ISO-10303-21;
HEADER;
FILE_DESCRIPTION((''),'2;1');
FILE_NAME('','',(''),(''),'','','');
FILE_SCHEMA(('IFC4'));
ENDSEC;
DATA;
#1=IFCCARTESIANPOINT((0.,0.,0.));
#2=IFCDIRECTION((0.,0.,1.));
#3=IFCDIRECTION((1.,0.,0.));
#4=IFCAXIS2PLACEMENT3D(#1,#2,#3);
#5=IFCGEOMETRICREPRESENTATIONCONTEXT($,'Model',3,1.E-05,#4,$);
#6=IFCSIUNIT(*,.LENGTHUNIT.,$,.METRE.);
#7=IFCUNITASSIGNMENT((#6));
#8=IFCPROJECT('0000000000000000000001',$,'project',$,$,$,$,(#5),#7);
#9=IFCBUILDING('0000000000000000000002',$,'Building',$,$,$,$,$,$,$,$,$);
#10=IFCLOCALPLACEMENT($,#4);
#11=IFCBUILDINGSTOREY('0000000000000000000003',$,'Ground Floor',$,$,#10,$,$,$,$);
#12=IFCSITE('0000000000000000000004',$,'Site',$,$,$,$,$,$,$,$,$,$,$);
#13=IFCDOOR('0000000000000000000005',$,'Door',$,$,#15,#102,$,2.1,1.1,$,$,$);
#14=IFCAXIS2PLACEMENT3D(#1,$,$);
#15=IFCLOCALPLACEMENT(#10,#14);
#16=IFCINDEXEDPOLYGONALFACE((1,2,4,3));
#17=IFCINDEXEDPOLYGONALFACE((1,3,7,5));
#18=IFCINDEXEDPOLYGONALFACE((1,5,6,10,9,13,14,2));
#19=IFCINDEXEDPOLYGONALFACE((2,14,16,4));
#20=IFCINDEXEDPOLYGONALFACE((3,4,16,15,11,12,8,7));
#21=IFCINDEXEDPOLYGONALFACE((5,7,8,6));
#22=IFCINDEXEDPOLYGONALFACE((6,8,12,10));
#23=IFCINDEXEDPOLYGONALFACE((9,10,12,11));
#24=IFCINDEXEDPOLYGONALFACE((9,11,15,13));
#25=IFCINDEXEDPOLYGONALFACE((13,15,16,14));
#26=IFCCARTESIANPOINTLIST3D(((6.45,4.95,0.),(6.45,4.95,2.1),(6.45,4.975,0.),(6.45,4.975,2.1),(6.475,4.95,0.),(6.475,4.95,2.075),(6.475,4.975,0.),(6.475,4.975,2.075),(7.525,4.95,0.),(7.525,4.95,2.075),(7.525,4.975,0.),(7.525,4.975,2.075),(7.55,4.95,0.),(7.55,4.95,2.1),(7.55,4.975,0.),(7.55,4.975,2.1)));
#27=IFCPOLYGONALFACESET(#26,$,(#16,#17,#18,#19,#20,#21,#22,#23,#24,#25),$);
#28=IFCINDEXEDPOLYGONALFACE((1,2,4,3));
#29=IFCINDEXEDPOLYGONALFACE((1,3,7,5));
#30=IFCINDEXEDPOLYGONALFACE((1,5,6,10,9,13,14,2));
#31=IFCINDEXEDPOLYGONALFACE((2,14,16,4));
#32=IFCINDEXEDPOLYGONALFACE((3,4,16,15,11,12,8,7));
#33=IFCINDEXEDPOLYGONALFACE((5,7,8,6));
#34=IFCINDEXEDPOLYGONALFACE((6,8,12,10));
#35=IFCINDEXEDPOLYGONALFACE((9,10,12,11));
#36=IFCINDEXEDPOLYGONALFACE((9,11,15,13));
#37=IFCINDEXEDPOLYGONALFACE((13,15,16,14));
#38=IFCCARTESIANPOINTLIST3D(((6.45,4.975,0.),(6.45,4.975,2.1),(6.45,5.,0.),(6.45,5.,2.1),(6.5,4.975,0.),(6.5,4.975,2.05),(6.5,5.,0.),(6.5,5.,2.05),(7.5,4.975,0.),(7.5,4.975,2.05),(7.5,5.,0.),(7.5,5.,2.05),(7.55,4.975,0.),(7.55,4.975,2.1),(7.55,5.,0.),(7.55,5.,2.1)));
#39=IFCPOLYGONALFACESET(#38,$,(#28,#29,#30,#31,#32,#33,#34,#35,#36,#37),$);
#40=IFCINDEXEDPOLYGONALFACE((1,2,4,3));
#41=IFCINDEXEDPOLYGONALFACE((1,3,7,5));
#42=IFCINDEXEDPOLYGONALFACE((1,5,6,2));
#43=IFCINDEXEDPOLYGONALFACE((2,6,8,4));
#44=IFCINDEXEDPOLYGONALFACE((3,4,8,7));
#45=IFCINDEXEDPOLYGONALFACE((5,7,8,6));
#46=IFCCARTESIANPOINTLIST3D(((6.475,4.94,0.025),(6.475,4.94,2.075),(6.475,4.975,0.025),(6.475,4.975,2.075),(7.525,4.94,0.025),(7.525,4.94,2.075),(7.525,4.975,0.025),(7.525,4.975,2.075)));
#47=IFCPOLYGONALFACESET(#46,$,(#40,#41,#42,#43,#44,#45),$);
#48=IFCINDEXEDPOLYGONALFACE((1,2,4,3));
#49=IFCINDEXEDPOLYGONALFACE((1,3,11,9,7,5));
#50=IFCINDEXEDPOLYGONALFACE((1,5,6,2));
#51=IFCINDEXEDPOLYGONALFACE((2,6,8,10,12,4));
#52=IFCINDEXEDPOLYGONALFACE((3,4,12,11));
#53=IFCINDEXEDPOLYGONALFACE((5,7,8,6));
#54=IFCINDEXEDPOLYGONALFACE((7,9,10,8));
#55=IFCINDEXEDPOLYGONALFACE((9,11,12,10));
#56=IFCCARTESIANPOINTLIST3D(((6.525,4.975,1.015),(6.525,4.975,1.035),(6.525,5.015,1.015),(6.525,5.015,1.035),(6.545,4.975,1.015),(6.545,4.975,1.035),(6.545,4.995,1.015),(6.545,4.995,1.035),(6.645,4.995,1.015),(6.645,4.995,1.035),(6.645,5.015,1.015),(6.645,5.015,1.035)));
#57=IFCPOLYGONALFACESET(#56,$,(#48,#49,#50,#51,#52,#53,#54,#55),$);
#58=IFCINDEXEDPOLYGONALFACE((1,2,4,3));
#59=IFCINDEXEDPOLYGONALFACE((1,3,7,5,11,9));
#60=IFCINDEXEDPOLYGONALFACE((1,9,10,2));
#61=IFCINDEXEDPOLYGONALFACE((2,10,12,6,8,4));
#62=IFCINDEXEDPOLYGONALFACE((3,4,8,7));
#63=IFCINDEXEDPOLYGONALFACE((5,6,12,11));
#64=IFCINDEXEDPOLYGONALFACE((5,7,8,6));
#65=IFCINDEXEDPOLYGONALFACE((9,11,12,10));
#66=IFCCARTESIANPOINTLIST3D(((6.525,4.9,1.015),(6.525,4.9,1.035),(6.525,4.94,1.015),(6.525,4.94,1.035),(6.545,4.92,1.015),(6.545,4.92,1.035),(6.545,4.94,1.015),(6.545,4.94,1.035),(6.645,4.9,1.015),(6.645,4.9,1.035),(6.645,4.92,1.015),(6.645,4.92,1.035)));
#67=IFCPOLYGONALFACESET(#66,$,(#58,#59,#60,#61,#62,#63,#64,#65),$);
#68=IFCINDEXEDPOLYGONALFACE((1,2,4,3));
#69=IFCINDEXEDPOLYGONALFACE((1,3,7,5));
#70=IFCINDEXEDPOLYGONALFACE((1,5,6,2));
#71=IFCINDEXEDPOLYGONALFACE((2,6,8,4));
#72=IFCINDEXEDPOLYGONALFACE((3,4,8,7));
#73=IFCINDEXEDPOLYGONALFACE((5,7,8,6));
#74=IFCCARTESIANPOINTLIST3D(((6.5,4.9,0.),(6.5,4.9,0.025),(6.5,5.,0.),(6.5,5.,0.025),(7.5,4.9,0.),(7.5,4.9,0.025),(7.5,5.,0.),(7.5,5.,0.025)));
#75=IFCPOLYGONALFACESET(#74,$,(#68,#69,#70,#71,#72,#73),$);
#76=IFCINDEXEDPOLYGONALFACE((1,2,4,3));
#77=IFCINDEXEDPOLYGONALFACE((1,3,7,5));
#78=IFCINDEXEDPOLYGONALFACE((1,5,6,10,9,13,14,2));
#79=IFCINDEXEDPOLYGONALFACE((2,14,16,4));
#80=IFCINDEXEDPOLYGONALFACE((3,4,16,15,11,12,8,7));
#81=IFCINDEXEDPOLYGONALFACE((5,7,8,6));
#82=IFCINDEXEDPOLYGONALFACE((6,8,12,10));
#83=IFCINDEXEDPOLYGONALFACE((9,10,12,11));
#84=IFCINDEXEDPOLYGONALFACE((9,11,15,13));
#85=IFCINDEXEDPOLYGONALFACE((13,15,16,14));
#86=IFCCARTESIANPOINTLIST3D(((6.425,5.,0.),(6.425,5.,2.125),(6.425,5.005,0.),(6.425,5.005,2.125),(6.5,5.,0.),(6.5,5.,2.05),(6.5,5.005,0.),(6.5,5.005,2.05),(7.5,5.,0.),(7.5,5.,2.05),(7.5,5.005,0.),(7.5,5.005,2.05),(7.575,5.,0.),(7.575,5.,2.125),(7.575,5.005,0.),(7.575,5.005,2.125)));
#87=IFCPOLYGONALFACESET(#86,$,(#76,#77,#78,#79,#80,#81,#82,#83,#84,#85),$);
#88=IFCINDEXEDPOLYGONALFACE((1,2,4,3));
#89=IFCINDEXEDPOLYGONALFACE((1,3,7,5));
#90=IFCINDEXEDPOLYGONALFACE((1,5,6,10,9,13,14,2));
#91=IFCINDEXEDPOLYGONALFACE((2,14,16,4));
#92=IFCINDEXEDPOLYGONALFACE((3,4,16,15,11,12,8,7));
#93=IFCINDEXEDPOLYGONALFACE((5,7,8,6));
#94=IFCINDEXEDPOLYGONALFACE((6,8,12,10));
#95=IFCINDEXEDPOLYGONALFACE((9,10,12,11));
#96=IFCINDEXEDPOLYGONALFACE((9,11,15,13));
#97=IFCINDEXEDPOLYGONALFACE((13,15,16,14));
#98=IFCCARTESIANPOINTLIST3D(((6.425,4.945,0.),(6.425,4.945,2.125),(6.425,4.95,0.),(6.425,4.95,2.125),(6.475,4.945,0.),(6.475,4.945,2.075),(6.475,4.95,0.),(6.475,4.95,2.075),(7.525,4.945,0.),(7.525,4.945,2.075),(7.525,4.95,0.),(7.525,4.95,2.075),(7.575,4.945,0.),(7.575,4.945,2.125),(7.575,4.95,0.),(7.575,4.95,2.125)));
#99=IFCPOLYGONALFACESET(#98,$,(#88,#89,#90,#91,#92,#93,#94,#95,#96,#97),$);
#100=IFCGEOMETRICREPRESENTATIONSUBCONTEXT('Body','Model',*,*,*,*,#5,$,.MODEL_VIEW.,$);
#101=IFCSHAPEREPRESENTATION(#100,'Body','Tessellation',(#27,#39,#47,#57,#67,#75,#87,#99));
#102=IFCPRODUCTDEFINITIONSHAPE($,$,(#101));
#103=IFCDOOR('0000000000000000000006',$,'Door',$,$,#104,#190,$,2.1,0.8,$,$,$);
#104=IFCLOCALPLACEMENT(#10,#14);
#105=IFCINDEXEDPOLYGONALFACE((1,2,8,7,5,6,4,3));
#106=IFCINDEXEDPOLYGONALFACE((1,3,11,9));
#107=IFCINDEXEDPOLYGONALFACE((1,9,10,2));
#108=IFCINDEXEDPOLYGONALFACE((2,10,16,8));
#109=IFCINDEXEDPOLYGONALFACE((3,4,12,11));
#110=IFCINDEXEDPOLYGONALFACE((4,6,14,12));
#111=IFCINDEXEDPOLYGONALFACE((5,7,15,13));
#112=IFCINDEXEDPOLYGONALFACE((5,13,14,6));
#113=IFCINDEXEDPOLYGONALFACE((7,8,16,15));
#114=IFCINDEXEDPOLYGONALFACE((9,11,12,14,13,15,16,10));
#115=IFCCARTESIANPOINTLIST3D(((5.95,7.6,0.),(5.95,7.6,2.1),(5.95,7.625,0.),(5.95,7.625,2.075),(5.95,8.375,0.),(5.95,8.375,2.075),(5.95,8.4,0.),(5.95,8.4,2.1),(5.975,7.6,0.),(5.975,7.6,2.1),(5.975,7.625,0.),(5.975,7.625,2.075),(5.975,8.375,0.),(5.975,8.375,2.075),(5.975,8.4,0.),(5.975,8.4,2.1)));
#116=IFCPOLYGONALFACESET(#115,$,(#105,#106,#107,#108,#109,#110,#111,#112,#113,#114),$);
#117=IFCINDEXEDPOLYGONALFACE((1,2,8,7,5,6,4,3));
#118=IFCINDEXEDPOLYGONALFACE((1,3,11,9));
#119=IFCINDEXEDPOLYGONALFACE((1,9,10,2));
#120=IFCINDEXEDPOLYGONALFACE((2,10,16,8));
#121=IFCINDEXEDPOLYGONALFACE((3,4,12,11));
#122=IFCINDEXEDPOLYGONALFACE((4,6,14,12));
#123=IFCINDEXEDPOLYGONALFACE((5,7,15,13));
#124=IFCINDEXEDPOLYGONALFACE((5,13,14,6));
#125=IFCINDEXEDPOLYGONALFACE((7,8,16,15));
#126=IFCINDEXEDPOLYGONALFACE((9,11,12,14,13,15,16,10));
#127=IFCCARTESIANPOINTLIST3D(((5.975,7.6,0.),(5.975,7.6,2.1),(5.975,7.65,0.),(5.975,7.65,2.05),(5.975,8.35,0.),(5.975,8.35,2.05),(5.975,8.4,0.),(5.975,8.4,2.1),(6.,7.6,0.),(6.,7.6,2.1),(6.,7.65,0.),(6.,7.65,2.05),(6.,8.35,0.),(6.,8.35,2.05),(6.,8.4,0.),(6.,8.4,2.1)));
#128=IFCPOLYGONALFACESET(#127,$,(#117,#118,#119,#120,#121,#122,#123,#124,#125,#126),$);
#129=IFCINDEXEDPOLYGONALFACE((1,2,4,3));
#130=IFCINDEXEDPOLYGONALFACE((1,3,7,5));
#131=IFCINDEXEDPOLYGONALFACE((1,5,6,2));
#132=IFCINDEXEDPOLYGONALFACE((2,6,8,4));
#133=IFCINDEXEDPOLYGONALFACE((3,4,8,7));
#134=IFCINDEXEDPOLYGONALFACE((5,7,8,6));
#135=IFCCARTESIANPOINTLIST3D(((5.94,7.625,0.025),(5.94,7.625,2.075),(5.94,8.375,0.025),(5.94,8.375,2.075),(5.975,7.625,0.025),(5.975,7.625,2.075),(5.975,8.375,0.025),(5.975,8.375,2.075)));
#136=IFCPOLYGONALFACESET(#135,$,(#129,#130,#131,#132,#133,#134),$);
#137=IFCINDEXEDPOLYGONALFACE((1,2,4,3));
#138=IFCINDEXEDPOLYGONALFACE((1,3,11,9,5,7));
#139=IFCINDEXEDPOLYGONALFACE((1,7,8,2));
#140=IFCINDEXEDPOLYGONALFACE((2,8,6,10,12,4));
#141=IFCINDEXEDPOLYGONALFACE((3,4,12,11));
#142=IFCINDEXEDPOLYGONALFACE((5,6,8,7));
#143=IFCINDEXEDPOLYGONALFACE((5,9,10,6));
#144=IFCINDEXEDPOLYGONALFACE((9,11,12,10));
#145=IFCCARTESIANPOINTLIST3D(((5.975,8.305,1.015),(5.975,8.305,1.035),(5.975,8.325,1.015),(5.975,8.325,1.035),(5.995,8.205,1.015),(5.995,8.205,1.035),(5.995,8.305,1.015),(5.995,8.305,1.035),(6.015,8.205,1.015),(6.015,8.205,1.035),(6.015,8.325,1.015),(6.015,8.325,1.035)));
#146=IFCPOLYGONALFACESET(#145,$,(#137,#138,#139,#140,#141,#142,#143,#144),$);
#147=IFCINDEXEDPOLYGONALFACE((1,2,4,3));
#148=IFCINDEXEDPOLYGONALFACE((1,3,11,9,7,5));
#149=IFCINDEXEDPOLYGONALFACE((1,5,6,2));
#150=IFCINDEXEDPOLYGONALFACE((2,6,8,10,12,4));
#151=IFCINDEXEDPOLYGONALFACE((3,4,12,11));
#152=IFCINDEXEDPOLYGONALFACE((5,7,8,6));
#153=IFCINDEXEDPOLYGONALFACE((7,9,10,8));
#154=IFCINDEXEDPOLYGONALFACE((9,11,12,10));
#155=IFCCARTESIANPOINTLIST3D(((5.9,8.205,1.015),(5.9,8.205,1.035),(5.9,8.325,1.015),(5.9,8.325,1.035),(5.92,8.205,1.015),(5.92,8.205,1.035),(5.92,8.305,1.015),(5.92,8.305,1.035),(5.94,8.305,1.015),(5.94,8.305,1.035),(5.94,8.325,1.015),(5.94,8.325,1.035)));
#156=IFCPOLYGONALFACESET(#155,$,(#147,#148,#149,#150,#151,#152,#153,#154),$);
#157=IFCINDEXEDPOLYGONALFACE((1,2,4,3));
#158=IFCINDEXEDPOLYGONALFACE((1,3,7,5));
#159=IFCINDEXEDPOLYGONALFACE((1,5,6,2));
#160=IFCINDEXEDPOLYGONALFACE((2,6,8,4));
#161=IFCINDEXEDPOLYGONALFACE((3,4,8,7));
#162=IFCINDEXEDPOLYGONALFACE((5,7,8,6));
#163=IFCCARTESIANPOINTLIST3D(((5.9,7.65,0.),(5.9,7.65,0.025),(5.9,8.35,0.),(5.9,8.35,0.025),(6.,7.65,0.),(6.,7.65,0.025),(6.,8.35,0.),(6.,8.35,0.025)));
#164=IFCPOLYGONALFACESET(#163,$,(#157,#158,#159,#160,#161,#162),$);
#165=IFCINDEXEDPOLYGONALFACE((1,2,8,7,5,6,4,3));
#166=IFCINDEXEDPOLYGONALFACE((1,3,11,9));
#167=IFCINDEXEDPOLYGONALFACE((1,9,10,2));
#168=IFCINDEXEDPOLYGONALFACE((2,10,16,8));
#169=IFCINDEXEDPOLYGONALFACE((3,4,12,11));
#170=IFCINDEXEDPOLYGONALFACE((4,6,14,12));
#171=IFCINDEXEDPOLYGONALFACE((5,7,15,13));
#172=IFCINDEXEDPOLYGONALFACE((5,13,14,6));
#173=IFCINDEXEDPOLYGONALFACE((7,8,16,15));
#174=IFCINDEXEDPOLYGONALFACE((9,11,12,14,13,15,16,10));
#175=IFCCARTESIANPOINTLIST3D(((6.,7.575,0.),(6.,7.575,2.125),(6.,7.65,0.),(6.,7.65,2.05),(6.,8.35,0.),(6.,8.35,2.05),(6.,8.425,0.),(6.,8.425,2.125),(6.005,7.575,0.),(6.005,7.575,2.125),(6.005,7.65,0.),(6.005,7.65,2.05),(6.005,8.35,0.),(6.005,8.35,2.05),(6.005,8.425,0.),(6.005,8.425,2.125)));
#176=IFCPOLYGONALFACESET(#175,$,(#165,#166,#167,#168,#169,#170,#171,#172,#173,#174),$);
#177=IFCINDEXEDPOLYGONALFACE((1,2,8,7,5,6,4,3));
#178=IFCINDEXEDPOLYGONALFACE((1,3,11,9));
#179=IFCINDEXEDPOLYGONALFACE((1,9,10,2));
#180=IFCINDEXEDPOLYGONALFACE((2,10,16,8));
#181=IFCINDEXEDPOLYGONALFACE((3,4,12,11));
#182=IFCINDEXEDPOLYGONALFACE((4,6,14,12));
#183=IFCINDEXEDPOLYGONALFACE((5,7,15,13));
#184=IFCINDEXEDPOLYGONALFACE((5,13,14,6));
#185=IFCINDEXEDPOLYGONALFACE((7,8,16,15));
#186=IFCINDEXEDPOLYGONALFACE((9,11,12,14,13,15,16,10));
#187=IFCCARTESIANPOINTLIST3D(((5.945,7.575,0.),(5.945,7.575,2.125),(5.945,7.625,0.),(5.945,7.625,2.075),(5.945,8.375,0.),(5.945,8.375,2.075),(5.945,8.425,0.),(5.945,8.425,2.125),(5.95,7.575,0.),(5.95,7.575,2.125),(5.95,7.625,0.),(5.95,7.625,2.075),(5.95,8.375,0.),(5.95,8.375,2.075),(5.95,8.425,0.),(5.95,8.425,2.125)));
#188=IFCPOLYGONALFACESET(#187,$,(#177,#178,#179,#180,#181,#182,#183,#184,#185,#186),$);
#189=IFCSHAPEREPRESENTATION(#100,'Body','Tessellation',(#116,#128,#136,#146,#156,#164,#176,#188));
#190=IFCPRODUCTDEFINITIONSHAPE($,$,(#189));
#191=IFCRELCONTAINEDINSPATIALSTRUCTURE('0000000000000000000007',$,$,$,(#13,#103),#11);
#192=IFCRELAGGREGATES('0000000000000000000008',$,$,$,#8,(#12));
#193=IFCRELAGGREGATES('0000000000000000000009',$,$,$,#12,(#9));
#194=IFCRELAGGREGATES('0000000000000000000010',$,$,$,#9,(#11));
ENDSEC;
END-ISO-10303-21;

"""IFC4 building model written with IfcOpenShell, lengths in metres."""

from ifc_helpers import new_model, si_unit, frame, origin_with_axes, place, context, subcontext, project, spatial, line, indexed_curve, outline, extrude, element, save


model = new_model("IFC4")

# Units and contexts
model_context = context("Model", 3, precision=1e-05, world=origin_with_axes())
body_context = subcontext(model_context, "Body", "Model", "MODEL_VIEW")
ifc_project = project(units=[si_unit("LENGTHUNIT", "METRE")], contexts=[model_context])

# Site, building, storey
site = spatial("IfcSite", under=ifc_project, Name="Site")
building = spatial("IfcBuilding", under=site, Name="Building")
storey_placement = place(None, origin_with_axes())
storey = spatial("IfcBuildingStorey", under=building, at=storey_placement, Name="Ground Floor")

# Doors
door_1_placement = place(storey_placement, frame((7.55, 5.0, 0.0), z_axis=(0.0, 0.0, 1.0), x_axis=(-1.0, 0.0, 0.0)))
element("IfcDoor", 1, at=door_1_placement, inside=storey, Name="Door", OverallHeight=2.1, OverallWidth=1.1, context=body_context, shape_type="SweptSolid", body=[
    extrude(outline(indexed_curve([(0.0, 0.0), (0.0, 2.1), (1.1, 2.1), (1.1, 0.0), (1.075, 0.0), (1.075, 2.075), (0.025, 2.075), (0.025, 0.0)], segments=[line(1, 2, 3, 4, 5, 6, 7, 8, 1)])), frame((0.0, 0.025, 0.0), z_axis=(0.0, -1.0, 0.0), x_axis=(1.0, 0.0, 0.0)), (0.0, 0.0, -1.0), 0.025),
    extrude(outline(indexed_curve([(0.0, 0.0), (0.0, 2.1), (1.1, 2.1), (1.1, 0.0), (1.05, 0.0), (1.05, 2.05), (0.05, 2.05), (0.05, 0.0)], segments=[line(1, 2, 3, 4, 5, 6, 7, 8, 1)])), frame((0.0, 0.0, 0.0), z_axis=(0.0, -1.0, 0.0), x_axis=(1.0, 0.0, 0.0)), (0.0, 0.0, -1.0), 0.025),
    extrude(outline(indexed_curve([(0.0, 0.0), (1.05, 0.0), (1.05, 0.035), (0.0, 0.035)], segments=[line(1, 2, 3, 4, 1)])), frame((0.025, 0.025, 0.025), z_axis=(0.0, 0.0, 1.0), x_axis=(1.0, 0.0, 0.0)), (0.0, 0.0, 1.0), 2.05),
    extrude(outline(indexed_curve([(0.0, 0.0), (0.0, -0.04), (-0.12, -0.04), (-0.12, -0.02), (-0.02, -0.02), (-0.02, 0.0)], segments=[line(1, 2, 3, 4, 5, 6, 1)])), frame((1.025, 0.025, 1.015), z_axis=(0.0, 0.0, 1.0), x_axis=(1.0, 0.0, 0.0)), (0.0, 0.0, 1.0), 0.02),
    extrude(outline(indexed_curve([(0.0, 0.0), (0.0, 0.04), (-0.12, 0.04), (-0.12, 0.02), (-0.02, 0.02), (-0.02, 0.0)], segments=[line(1, 2, 3, 4, 5, 6, 1)])), frame((1.025, 0.06, 1.015), z_axis=(0.0, 0.0, 1.0), x_axis=(1.0, 0.0, 0.0)), (0.0, 0.0, 1.0), 0.02),
    extrude(outline(indexed_curve([(0.0, 0.0), (1.0, 0.0), (1.0, 0.1), (0.0, 0.1)], segments=[line(1, 2, 3, 4, 1)])), frame((0.05, 0.0, 0.0), z_axis=(0.0, 0.0, 1.0), x_axis=(1.0, 0.0, 0.0)), (0.0, 0.0, 1.0), 0.025),
    extrude(outline(indexed_curve([(0.0, 0.0), (0.0, 2.125), (1.15, 2.125), (1.15, 0.0), (1.075, 0.0), (1.075, 2.05), (0.075, 2.05), (0.075, 0.0)], segments=[line(1, 2, 3, 4, 5, 6, 7, 8, 1)])), frame((-0.025, -0.005, 0.0), z_axis=(0.0, -1.0, 0.0), x_axis=(1.0, 0.0, 0.0)), (0.0, 0.0, -1.0), 0.005),
    extrude(outline(indexed_curve([(0.0, 0.0), (0.0, 2.125), (1.15, 2.125), (1.15, 0.0), (1.1, 0.0), (1.1, 2.075), (0.05, 2.075), (0.05, 0.0)], segments=[line(1, 2, 3, 4, 5, 6, 7, 8, 1)])), frame((-0.025, 0.05, 0.0), z_axis=(0.0, -1.0, 0.0), x_axis=(1.0, 0.0, 0.0)), (0.0, 0.0, -1.0), 0.005),
])
door_2_placement = place(storey_placement, frame((6.0, 7.6, 0.0), z_axis=(0.0, 0.0, 1.0), x_axis=(0.0, 1.0, 0.0)))
element("IfcDoor", 2, at=door_2_placement, inside=storey, Name="Door", OverallHeight=2.1, OverallWidth=0.8, context=body_context, shape_type="SweptSolid", body=[
    extrude(outline(indexed_curve([(0.0, 0.0), (0.0, 2.1), (0.8, 2.1), (0.8, 0.0), (0.775, 0.0), (0.775, 2.075), (0.025, 2.075), (0.025, 0.0)], segments=[line(1, 2, 3, 4, 5, 6, 7, 8, 1)])), frame((0.0, 0.025, 0.0), z_axis=(0.0, -1.0, 0.0), x_axis=(1.0, 0.0, 0.0)), (0.0, 0.0, -1.0), 0.025),
    extrude(outline(indexed_curve([(0.0, 0.0), (0.0, 2.1), (0.8, 2.1), (0.8, 0.0), (0.75, 0.0), (0.75, 2.05), (0.05, 2.05), (0.05, 0.0)], segments=[line(1, 2, 3, 4, 5, 6, 7, 8, 1)])), frame((0.0, 0.0, 0.0), z_axis=(0.0, -1.0, 0.0), x_axis=(1.0, 0.0, 0.0)), (0.0, 0.0, -1.0), 0.025),
    extrude(outline(indexed_curve([(0.0, 0.0), (0.75, 0.0), (0.75, 0.035), (0.0, 0.035)], segments=[line(1, 2, 3, 4, 1)])), frame((0.025, 0.025, 0.025), z_axis=(0.0, 0.0, 1.0), x_axis=(1.0, 0.0, 0.0)), (0.0, 0.0, 1.0), 2.05),
    extrude(outline(indexed_curve([(0.0, 0.0), (0.0, -0.04), (-0.12, -0.04), (-0.12, -0.02), (-0.02, -0.02), (-0.02, 0.0)], segments=[line(1, 2, 3, 4, 5, 6, 1)])), frame((0.725, 0.025, 1.015), z_axis=(0.0, 0.0, 1.0), x_axis=(1.0, 0.0, 0.0)), (0.0, 0.0, 1.0), 0.02),
    extrude(outline(indexed_curve([(0.0, 0.0), (0.0, 0.04), (-0.12, 0.04), (-0.12, 0.02), (-0.02, 0.02), (-0.02, 0.0)], segments=[line(1, 2, 3, 4, 5, 6, 1)])), frame((0.725, 0.06, 1.015), z_axis=(0.0, 0.0, 1.0), x_axis=(1.0, 0.0, 0.0)), (0.0, 0.0, 1.0), 0.02),
    extrude(outline(indexed_curve([(0.0, 0.0), (0.7, 0.0), (0.7, 0.1), (0.0, 0.1)], segments=[line(1, 2, 3, 4, 1)])), frame((0.05, 0.0, 0.0), z_axis=(0.0, 0.0, 1.0), x_axis=(1.0, 0.0, 0.0)), (0.0, 0.0, 1.0), 0.025),
    extrude(outline(indexed_curve([(0.0, 0.0), (0.0, 2.125), (0.85, 2.125), (0.85, 0.0), (0.775, 0.0), (0.775, 2.05), (0.075, 2.05), (0.075, 0.0)], segments=[line(1, 2, 3, 4, 5, 6, 7, 8, 1)])), frame((-0.025, -0.005, 0.0), z_axis=(0.0, -1.0, 0.0), x_axis=(1.0, 0.0, 0.0)), (0.0, 0.0, -1.0), 0.005),
    extrude(outline(indexed_curve([(0.0, 0.0), (0.0, 2.125), (0.85, 2.125), (0.85, 0.0), (0.8, 0.0), (0.8, 2.075), (0.05, 2.075), (0.05, 0.0)], segments=[line(1, 2, 3, 4, 5, 6, 7, 8, 1)])), frame((-0.025, 0.05, 0.0), z_axis=(0.0, -1.0, 0.0), x_axis=(1.0, 0.0, 0.0)), (0.0, 0.0, -1.0), 0.005),
])

save(model, "model.ifc")
